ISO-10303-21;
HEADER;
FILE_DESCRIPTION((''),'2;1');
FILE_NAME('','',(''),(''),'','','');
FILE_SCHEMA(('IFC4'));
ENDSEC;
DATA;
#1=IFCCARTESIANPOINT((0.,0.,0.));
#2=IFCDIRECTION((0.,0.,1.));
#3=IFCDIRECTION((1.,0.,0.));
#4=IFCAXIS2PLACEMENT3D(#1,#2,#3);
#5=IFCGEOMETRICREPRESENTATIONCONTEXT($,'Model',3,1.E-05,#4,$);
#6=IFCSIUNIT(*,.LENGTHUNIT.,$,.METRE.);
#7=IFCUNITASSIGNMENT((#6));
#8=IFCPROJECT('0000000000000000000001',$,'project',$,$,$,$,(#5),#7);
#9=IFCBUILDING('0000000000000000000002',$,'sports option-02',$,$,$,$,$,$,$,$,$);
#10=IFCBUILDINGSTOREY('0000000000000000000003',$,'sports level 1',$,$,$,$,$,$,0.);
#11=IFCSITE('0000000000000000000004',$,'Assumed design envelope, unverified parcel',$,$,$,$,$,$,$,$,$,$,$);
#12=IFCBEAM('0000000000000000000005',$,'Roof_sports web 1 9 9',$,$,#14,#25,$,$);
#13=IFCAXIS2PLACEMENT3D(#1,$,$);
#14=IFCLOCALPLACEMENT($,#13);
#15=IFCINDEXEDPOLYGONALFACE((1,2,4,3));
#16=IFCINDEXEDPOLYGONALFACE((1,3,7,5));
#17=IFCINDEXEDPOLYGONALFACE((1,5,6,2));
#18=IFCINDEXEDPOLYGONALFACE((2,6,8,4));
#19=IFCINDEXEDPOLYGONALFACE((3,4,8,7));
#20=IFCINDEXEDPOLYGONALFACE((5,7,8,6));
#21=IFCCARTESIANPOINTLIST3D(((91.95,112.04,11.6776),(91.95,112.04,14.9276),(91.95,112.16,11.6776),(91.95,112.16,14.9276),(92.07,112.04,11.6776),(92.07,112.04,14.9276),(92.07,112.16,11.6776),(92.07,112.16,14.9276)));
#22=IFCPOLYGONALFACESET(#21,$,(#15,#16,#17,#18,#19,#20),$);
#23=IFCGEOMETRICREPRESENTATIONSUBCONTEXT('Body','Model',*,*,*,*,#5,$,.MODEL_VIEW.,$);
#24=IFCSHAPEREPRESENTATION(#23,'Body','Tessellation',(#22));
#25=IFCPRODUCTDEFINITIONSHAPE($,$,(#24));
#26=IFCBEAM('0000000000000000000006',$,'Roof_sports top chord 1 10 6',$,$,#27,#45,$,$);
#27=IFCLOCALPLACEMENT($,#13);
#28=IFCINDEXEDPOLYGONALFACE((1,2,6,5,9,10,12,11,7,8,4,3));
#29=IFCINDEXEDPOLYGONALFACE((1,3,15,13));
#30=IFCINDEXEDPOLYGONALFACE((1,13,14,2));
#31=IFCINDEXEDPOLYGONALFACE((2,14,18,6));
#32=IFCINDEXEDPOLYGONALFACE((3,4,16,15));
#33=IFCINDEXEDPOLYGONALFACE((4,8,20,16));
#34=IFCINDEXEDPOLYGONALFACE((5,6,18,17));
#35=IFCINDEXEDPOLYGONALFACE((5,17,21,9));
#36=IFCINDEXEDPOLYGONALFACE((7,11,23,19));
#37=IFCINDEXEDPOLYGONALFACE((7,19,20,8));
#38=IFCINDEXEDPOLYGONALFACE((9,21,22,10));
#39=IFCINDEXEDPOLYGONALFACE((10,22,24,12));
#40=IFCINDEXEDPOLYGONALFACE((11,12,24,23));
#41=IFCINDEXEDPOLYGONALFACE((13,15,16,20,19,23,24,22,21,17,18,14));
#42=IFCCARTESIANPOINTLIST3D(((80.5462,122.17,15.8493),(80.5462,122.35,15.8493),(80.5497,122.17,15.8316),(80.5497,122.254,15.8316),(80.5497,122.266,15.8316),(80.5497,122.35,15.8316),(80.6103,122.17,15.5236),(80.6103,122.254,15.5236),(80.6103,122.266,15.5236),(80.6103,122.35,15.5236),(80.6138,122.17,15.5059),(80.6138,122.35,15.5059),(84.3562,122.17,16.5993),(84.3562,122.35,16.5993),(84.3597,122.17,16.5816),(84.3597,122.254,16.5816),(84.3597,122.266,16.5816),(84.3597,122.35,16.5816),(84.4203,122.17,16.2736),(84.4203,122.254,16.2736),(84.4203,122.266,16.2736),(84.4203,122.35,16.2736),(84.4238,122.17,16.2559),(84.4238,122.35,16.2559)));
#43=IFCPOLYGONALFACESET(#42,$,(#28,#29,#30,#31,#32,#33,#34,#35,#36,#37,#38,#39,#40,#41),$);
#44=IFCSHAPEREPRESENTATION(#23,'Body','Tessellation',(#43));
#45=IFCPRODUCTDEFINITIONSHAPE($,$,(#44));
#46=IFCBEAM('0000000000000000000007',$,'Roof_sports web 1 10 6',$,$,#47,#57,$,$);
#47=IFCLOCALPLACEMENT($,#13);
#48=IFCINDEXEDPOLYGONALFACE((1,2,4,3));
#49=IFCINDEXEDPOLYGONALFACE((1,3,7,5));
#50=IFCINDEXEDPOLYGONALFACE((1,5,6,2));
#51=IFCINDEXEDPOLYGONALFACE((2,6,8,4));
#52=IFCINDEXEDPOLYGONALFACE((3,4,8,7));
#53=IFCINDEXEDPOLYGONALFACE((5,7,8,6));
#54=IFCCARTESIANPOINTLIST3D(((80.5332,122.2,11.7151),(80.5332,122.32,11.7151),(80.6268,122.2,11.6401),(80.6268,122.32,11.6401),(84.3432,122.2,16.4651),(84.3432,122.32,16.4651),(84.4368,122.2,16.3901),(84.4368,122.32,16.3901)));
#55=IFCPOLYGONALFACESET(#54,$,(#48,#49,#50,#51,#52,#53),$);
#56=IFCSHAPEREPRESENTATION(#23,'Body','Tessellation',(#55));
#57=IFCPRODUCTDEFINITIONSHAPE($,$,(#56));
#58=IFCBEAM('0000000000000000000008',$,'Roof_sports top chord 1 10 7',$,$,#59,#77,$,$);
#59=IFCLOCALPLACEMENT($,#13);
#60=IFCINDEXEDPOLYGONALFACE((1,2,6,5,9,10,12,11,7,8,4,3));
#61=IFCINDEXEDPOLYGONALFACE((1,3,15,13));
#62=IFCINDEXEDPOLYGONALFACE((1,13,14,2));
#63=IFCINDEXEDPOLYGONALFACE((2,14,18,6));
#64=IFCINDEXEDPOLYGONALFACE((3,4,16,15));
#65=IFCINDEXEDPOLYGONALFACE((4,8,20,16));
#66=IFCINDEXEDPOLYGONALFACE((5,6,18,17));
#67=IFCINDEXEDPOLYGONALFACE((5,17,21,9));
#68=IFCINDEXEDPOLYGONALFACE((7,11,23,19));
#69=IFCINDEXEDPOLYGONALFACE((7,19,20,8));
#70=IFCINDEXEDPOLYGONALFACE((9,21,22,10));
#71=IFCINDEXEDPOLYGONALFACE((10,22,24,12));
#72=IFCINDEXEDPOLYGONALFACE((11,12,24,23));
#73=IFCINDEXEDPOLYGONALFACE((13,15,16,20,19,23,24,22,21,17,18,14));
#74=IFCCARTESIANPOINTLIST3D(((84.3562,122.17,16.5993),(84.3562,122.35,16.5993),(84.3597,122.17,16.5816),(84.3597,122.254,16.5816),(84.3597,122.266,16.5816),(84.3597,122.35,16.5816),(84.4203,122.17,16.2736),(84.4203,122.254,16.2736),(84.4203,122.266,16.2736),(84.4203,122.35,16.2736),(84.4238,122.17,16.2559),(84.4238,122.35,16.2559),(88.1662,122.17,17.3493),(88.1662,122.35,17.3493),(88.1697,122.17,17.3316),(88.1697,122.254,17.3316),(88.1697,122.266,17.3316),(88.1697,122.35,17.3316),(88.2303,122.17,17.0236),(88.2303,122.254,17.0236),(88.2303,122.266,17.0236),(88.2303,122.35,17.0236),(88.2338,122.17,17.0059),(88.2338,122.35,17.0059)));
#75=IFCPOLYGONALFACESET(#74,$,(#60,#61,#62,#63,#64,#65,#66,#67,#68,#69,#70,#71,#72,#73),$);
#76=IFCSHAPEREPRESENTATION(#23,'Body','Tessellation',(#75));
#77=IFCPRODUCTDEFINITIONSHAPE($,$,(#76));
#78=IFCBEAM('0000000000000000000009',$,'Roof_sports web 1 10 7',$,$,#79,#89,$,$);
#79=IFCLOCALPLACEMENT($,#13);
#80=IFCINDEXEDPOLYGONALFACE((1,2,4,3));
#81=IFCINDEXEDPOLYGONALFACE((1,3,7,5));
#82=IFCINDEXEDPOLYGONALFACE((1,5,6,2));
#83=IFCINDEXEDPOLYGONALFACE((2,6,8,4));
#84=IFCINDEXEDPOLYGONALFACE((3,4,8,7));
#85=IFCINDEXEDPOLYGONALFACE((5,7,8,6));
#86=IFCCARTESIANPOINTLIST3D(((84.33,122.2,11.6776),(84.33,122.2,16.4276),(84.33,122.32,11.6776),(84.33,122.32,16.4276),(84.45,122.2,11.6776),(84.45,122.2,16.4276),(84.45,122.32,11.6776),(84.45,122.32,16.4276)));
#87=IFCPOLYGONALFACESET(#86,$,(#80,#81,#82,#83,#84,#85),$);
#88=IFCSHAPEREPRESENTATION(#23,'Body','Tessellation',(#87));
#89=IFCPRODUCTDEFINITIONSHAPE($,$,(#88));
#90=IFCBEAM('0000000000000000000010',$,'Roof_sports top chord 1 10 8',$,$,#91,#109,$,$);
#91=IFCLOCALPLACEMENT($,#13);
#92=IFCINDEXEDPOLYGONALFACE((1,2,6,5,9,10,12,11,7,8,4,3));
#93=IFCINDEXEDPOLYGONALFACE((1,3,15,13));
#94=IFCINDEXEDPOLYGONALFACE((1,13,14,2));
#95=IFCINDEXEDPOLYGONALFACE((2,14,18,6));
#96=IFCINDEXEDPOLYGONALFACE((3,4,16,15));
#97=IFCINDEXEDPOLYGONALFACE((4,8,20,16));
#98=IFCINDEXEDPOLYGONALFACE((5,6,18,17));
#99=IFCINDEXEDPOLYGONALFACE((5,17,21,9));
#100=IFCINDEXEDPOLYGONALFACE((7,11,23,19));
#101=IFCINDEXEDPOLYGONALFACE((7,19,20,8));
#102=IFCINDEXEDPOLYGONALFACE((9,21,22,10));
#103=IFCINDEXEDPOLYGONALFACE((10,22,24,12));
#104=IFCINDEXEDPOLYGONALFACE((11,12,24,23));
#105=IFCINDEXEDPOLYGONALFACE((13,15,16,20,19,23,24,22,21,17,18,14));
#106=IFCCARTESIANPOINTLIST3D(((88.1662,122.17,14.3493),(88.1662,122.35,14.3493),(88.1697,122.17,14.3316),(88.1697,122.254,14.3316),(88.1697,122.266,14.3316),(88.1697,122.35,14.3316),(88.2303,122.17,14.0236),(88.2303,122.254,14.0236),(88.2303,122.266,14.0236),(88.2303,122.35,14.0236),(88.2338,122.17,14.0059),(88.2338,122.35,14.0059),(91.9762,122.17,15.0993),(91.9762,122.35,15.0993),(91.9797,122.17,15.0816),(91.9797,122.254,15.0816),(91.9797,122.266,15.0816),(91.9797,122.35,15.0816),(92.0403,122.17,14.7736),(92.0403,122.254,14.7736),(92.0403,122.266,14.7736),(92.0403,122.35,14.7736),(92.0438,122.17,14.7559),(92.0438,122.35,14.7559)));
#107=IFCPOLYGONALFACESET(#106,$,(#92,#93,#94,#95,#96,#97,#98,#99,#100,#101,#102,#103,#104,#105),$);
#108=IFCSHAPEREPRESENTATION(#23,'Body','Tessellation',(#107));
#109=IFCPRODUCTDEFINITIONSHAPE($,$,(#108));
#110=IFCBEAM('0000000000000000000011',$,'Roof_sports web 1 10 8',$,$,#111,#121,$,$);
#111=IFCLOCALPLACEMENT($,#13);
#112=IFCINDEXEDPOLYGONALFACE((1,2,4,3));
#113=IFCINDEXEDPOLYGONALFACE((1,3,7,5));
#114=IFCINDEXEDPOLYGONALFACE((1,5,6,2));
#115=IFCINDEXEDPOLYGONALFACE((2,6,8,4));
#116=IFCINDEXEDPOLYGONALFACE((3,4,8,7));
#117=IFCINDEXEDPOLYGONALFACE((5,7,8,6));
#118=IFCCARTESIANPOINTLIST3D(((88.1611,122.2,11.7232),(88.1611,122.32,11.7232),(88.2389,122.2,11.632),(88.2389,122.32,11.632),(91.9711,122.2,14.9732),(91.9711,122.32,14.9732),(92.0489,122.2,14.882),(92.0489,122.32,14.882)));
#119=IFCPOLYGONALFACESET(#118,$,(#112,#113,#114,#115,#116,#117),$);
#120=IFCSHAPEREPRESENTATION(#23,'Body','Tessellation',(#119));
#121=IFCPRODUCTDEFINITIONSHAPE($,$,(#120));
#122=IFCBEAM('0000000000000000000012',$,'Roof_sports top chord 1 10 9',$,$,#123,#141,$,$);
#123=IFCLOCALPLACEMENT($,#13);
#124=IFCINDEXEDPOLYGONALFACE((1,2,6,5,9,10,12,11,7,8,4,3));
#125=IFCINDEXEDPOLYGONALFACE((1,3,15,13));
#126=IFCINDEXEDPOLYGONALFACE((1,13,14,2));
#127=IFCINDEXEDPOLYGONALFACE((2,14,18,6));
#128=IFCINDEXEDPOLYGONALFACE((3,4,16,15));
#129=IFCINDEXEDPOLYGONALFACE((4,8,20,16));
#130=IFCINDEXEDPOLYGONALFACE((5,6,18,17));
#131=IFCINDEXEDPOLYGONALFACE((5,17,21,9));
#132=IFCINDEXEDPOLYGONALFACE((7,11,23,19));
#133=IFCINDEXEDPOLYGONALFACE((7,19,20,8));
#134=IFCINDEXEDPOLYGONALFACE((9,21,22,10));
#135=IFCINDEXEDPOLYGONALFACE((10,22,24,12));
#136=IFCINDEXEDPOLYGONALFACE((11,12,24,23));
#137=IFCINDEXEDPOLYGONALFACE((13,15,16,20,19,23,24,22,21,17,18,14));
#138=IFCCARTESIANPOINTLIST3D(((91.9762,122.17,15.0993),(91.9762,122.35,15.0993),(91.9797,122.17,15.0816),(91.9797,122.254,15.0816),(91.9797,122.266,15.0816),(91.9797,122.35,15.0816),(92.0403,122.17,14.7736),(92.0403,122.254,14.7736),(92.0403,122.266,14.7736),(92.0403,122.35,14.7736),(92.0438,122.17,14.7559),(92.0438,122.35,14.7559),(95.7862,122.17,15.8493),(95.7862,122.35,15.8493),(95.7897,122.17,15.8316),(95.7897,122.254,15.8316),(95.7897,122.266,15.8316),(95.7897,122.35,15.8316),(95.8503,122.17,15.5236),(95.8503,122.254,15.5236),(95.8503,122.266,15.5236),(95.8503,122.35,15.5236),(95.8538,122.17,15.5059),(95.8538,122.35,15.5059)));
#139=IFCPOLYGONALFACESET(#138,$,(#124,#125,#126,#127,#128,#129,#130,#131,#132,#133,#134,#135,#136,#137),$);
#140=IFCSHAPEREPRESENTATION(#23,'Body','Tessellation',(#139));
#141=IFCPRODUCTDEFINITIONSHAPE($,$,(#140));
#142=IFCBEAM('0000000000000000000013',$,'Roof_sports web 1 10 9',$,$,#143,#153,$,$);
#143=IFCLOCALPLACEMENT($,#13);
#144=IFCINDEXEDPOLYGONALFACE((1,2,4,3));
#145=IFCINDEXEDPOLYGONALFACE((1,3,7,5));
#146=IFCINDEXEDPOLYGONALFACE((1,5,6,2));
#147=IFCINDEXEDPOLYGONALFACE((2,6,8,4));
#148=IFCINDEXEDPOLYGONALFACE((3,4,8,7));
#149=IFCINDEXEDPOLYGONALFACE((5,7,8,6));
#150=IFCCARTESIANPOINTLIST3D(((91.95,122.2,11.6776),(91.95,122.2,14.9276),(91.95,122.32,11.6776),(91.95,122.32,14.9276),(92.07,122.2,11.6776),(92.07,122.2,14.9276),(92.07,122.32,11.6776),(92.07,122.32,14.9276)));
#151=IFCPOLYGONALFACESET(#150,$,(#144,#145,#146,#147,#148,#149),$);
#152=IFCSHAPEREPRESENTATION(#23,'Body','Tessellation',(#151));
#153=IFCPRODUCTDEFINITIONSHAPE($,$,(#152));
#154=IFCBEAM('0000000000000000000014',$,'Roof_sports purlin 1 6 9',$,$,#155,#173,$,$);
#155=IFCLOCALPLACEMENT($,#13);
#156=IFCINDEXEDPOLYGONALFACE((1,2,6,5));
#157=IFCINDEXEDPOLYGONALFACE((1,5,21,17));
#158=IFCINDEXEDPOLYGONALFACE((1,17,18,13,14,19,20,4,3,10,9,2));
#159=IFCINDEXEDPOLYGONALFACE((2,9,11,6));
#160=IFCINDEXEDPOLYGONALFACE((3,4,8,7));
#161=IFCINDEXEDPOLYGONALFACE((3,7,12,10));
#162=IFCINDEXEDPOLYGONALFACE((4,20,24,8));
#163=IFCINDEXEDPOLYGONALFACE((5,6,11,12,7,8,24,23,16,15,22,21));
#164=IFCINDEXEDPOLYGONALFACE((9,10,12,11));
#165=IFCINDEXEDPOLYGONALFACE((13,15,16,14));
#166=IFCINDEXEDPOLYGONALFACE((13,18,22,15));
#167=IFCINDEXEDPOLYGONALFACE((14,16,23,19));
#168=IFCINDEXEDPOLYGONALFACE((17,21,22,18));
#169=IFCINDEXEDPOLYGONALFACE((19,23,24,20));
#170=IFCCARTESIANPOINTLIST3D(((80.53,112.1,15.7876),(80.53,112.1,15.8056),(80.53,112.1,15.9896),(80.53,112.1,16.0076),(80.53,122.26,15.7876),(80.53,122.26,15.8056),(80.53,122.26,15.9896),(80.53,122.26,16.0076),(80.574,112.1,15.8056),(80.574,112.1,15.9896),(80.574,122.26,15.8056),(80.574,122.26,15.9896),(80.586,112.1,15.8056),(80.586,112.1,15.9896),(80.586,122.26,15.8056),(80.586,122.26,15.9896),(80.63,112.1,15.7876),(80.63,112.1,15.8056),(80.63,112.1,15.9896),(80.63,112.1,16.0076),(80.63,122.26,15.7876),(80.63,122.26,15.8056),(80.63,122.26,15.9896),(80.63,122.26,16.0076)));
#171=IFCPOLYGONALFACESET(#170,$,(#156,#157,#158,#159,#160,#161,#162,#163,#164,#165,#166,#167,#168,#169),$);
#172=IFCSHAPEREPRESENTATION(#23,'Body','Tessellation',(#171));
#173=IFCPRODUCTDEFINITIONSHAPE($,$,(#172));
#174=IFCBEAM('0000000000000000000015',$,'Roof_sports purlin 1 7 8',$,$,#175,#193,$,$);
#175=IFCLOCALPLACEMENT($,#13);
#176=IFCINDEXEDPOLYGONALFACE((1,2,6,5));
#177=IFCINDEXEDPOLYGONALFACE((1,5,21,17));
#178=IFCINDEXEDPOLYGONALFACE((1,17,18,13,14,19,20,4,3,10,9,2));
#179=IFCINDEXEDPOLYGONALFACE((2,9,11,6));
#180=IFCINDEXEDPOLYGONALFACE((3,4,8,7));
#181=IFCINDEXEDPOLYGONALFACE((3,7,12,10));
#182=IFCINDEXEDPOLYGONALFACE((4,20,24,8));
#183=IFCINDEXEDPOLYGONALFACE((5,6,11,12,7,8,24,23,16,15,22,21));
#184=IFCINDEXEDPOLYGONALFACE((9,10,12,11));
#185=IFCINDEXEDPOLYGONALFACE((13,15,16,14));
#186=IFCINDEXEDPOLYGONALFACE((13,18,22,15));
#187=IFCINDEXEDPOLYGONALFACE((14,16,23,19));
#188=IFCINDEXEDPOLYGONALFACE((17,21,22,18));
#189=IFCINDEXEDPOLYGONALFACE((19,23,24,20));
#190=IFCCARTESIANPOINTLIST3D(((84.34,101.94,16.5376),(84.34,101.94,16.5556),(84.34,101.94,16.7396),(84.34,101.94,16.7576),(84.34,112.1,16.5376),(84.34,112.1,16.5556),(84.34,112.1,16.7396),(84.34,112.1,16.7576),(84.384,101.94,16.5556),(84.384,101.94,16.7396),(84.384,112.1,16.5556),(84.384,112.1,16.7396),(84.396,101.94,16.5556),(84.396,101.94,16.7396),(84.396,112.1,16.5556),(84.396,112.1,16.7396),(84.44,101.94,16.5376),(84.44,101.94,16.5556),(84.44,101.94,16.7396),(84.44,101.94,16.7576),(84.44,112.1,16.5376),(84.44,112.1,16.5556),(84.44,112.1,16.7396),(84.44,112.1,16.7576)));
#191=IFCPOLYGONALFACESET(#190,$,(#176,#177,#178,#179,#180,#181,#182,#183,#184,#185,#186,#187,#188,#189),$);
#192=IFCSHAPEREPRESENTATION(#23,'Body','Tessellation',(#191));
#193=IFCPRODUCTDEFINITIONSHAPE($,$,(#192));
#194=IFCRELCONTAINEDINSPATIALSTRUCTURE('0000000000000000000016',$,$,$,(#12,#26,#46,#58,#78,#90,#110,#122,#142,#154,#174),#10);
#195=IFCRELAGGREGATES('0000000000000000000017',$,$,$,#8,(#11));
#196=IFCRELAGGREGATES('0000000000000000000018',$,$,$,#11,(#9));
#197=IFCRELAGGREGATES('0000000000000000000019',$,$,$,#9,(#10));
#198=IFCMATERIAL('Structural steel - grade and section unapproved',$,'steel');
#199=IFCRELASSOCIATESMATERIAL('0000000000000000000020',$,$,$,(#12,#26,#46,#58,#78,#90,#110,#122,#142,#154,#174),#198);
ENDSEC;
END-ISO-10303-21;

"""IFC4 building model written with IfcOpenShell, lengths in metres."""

from ifc_helpers import new_model, si_unit, frame, origin_with_axes, place, context, subcontext, project, spatial, rectangle, i_section, extrude, material, element, save


model = new_model("IFC4")

# Units and contexts
model_context = context("Model", 3, precision=1e-05, world=origin_with_axes())
body_context = subcontext(model_context, "Body", "Model", "MODEL_VIEW")
ifc_project = project(units=[si_unit("LENGTHUNIT", "METRE")], contexts=[model_context])

# Site, building, storey
site = spatial("IfcSite", under=ifc_project, Name="Assumed design envelope, unverified parcel")
building = spatial("IfcBuilding", under=site, Name="sports option-02")
storey = spatial("IfcBuildingStorey", under=building, Name="sports level 1", Elevation=0.0)

# Beams
ifc_material_1 = material(Name="Structural steel - grade and section unapproved", Category="steel")
beam_1_placement = place(None, frame((92.01, 112.1, 11.6776), z_axis=(0.0, 0.0, 1.0), x_axis=(-1.0, 0.0, 0.0)))
element("IfcBeam", 1, at=beam_1_placement, inside=storey, material=ifc_material_1, Name="Roof_sports web 1 9 9", context=body_context, shape_type="SweptSolid", body=[
    extrude(rectangle(XDim=0.12, YDim=0.12), origin_with_axes(), (0.0, 0.0, 1.0), 3.25),
])
beam_2_placement = place(None, frame((80.58, 122.26, 15.6776), z_axis=(0.98117, 0.0, 0.193144), x_axis=(0.0, 1.0, 0.0)))
element("IfcBeam", 2, at=beam_2_placement, inside=storey, material=ifc_material_1, Name="Roof_sports top chord 1 10 6", context=body_context, shape_type="SweptSolid", body=[
    extrude(i_section(OverallWidth=0.18, OverallDepth=0.35, WebThickness=0.012, FlangeThickness=0.018, FilletRadius=0.0), origin_with_axes(), (0.0, 0.0, 1.0), 3.8831),
])
beam_3_placement = place(None, frame((80.58, 122.26, 11.6776), z_axis=(0.625696, 0.0, 0.780067), x_axis=(0.0, 1.0, 0.0)))
element("IfcBeam", 3, at=beam_3_placement, inside=storey, material=ifc_material_1, Name="Roof_sports web 1 10 6", context=body_context, shape_type="SweptSolid", body=[
    extrude(rectangle(XDim=0.12, YDim=0.12), origin_with_axes(), (0.0, 0.0, 1.0), 6.0892),
])
beam_4_placement = place(None, frame((84.39, 122.26, 16.4276), z_axis=(0.98117, 0.0, 0.193144), x_axis=(0.0, 1.0, 0.0)))
element("IfcBeam", 4, at=beam_4_placement, inside=storey, material=ifc_material_1, Name="Roof_sports top chord 1 10 7", context=body_context, shape_type="SweptSolid", body=[
    extrude(i_section(OverallWidth=0.18, OverallDepth=0.35, WebThickness=0.012, FlangeThickness=0.018, FilletRadius=0.0), origin_with_axes(), (0.0, 0.0, 1.0), 3.8831),
])
beam_5_placement = place(None, frame((84.39, 122.26, 11.6776), z_axis=(0.0, 0.0, 1.0), x_axis=(-1.0, 0.0, 0.0)))
element("IfcBeam", 5, at=beam_5_placement, inside=storey, material=ifc_material_1, Name="Roof_sports web 1 10 7", context=body_context, shape_type="SweptSolid", body=[
    extrude(rectangle(XDim=0.12, YDim=0.12), origin_with_axes(), (0.0, 0.0, 1.0), 4.75),
])
beam_6_placement = place(None, frame((88.2, 122.26, 14.1776), z_axis=(0.981171, 0.0, 0.193143), x_axis=(0.0, 1.0, 0.0)))
element("IfcBeam", 6, at=beam_6_placement, inside=storey, material=ifc_material_1, Name="Roof_sports top chord 1 10 8", context=body_context, shape_type="SweptSolid", body=[
    extrude(i_section(OverallWidth=0.18, OverallDepth=0.35, WebThickness=0.012, FlangeThickness=0.018, FilletRadius=0.0), origin_with_axes(), (0.0, 0.0, 1.0), 3.8831),
])
beam_7_placement = place(None, frame((88.2, 122.26, 11.6776), z_axis=(0.760805, 0.0, 0.64898), x_axis=(0.0, 1.0, 0.0)))
element("IfcBeam", 7, at=beam_7_placement, inside=storey, material=ifc_material_1, Name="Roof_sports web 1 10 8", context=body_context, shape_type="SweptSolid", body=[
    extrude(rectangle(XDim=0.12, YDim=0.12), origin_with_axes(), (0.0, 0.0, 1.0), 5.0079),
])
beam_8_placement = place(None, frame((92.01, 122.26, 14.9276), z_axis=(0.98117, 0.0, 0.193144), x_axis=(0.0, 1.0, 0.0)))
element("IfcBeam", 8, at=beam_8_placement, inside=storey, material=ifc_material_1, Name="Roof_sports top chord 1 10 9", context=body_context, shape_type="SweptSolid", body=[
    extrude(i_section(OverallWidth=0.18, OverallDepth=0.35, WebThickness=0.012, FlangeThickness=0.018, FilletRadius=0.0), origin_with_axes(), (0.0, 0.0, 1.0), 3.8831),
])
beam_9_placement = place(None, frame((92.01, 122.26, 11.6776), z_axis=(0.0, 0.0, 1.0), x_axis=(-1.0, 0.0, 0.0)))
element("IfcBeam", 9, at=beam_9_placement, inside=storey, material=ifc_material_1, Name="Roof_sports web 1 10 9", context=body_context, shape_type="SweptSolid", body=[
    extrude(rectangle(XDim=0.12, YDim=0.12), origin_with_axes(), (0.0, 0.0, 1.0), 3.25),
])
beam_10_placement = place(None, frame((80.58, 112.1, 15.8976), z_axis=(0.0, 1.0, 0.0), x_axis=(-1.0, 0.0, 0.0)))
element("IfcBeam", 10, at=beam_10_placement, inside=storey, material=ifc_material_1, Name="Roof_sports purlin 1 6 9", context=body_context, shape_type="SweptSolid", body=[
    extrude(i_section(OverallWidth=0.1, OverallDepth=0.22, WebThickness=0.012, FlangeThickness=0.018, FilletRadius=0.0), origin_with_axes(), (0.0, 0.0, 1.0), 10.16),
])
beam_11_placement = place(None, frame((84.39, 101.94, 16.6476), z_axis=(0.0, 1.0, 0.0), x_axis=(-1.0, 0.0, 0.0)))
element("IfcBeam", 11, at=beam_11_placement, inside=storey, material=ifc_material_1, Name="Roof_sports purlin 1 7 8", context=body_context, shape_type="SweptSolid", body=[
    extrude(i_section(OverallWidth=0.1, OverallDepth=0.22, WebThickness=0.012, FlangeThickness=0.018, FilletRadius=0.0), origin_with_axes(), (0.0, 0.0, 1.0), 10.16),
])

save(model, "model.ifc")
